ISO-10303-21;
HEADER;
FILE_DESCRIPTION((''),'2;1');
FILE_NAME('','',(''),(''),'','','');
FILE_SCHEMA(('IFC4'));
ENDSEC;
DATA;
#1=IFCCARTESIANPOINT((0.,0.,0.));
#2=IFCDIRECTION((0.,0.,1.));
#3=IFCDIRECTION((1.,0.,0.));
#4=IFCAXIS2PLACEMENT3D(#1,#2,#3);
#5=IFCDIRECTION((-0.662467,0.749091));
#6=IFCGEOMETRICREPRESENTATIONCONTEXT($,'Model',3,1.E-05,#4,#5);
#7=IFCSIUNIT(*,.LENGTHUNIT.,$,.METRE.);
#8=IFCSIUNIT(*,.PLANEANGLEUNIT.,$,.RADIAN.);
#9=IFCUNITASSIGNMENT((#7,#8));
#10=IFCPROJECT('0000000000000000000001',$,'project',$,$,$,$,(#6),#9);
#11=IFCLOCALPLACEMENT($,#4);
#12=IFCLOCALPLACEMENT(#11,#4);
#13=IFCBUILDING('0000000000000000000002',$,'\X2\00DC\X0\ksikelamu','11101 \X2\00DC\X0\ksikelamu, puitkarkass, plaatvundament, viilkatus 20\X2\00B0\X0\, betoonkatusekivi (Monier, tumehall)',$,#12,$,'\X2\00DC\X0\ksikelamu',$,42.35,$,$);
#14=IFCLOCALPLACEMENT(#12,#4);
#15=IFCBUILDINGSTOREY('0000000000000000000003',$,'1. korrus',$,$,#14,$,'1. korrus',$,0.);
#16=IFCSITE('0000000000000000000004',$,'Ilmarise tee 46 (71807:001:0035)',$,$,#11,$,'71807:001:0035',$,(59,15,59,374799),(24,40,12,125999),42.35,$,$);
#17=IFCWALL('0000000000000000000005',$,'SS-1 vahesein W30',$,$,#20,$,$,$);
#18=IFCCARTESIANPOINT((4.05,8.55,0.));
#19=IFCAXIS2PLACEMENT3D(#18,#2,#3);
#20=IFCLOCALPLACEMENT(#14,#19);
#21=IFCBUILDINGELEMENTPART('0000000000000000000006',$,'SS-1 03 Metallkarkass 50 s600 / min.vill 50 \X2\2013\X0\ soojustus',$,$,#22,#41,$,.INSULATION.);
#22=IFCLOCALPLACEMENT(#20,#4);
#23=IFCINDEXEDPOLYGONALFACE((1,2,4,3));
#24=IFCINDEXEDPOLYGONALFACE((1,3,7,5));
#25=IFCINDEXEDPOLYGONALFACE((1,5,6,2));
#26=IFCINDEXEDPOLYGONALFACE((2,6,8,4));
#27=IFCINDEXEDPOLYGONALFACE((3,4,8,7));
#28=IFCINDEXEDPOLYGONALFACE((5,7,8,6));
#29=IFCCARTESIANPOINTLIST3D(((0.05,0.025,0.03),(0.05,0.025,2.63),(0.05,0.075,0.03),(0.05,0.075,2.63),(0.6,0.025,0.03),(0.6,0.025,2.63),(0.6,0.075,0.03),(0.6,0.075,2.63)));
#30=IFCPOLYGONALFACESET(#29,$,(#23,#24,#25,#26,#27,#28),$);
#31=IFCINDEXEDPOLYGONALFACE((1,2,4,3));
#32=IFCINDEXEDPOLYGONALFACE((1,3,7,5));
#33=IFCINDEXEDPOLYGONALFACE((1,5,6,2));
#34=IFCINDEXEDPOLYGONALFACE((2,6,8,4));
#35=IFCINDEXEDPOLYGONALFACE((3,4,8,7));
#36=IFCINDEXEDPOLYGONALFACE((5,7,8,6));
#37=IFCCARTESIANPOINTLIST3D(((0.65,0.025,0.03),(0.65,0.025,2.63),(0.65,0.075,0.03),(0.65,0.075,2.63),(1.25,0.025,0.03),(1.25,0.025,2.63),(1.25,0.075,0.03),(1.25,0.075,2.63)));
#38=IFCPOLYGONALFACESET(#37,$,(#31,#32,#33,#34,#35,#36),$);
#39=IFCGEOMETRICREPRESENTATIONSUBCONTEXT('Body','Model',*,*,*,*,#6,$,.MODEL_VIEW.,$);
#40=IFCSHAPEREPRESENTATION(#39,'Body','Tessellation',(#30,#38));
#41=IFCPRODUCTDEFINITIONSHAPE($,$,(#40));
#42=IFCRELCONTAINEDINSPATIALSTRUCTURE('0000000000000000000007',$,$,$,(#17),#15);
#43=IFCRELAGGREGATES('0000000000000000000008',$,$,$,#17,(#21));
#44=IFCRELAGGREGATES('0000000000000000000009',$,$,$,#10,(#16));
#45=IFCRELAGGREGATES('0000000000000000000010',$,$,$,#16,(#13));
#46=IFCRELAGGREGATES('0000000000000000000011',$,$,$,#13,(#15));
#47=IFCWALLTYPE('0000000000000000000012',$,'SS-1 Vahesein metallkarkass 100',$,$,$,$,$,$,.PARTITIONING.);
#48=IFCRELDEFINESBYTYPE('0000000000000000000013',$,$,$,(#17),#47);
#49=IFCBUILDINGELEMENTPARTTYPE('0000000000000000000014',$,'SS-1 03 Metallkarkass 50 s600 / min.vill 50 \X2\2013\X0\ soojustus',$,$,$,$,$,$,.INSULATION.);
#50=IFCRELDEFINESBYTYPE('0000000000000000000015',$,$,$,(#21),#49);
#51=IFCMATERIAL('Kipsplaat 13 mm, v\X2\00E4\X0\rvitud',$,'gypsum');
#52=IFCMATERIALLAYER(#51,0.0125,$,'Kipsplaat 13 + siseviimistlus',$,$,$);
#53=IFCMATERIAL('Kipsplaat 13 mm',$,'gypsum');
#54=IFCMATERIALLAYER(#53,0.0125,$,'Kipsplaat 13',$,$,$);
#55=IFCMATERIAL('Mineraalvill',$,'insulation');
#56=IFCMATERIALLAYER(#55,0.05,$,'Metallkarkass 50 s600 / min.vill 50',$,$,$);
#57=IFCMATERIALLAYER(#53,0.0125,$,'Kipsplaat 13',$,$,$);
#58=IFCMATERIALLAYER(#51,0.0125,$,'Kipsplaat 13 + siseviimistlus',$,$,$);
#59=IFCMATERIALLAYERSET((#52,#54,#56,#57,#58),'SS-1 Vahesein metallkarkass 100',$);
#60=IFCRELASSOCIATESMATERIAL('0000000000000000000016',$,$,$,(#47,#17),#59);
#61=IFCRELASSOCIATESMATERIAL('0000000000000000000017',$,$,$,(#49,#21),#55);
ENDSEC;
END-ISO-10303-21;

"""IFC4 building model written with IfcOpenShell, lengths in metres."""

from ifc_helpers import new_model, si_unit, direction, frame, origin_with_axes, place, context, subcontext, project, spatial, indexed_curve, outline, extrude, material, layer, layer_set, layer_usage, type_object, element, aggregate, save


model = new_model("IFC4")

# Units and contexts
model_context = context("Model", 3, precision=1e-05, world=origin_with_axes(), true_north=direction((-0.662467, 0.749091)))
body_context = subcontext(model_context, "Body", "Model", "MODEL_VIEW")
ifc_project = project(units=[si_unit("LENGTHUNIT", "METRE"), si_unit("PLANEANGLEUNIT", "RADIAN")], contexts=[model_context])

# Site, building, storey
site_placement = place(None, origin_with_axes())
site = spatial("IfcSite", under=ifc_project, at=site_placement, Name="Ilmarise tee 46 (71807:001:0035)", LongName="71807:001:0035", RefLatitude=(59, 15, 59, 374799), RefLongitude=(24, 40, 12, 125999), RefElevation=42.35)
building_placement = place(site_placement, origin_with_axes())
building = spatial("IfcBuilding", under=site, at=building_placement, Name="Üksikelamu", Description="11101 Üksikelamu, puitkarkass, plaatvundament, viilkatus 20°, betoonkatusekivi (Monier, tumehall)", LongName="Üksikelamu", ElevationOfRefHeight=42.35)
storey_placement = place(building_placement, origin_with_axes())
storey = spatial("IfcBuildingStorey", under=building, at=storey_placement, Name="1. korrus", LongName="1. korrus", Elevation=0.0)

# Wall
ifc_material_1 = material(Name="Kipsplaat 13 mm, värvitud", Category="gypsum")
ifc_layer_1 = layer(ifc_material_1, 0.0125, Name="Kipsplaat 13 + siseviimistlus")
ifc_material_2 = material(Name="Kipsplaat 13 mm", Category="gypsum")
ifc_layer_2 = layer(ifc_material_2, 0.0125, Name="Kipsplaat 13")
ifc_material_3 = material(Name="Mineraalvill", Category="insulation")
ifc_layer_3 = layer(ifc_material_3, 0.05, Name="Metallkarkass 50 s600 / min.vill 50")
ifc_layer_4 = layer(ifc_material_2, 0.0125, Name="Kipsplaat 13")
ifc_layer_5 = layer(ifc_material_1, 0.0125, Name="Kipsplaat 13 + siseviimistlus")
ifc_layer_set = layer_set([ifc_layer_1, ifc_layer_2, ifc_layer_3, ifc_layer_4, ifc_layer_5], Name="SS-1 Vahesein metallkarkass 100")
ifc_layer_usage = layer_usage(ifc_layer_set, "AXIS2", "POSITIVE", 0.0)
wall_type = type_object("IfcWallType", Name="SS-1 Vahesein metallkarkass 100", PredefinedType="PARTITIONING", material=ifc_layer_set)
wall_placement = place(storey_placement, frame((4.05, 8.55, 0.0), z_axis=(0.0, 0.0, 1.0), x_axis=(1.0, 0.0, 0.0)))
wall = element("IfcWall", 1, at=wall_placement, inside=storey, type_object=wall_type, material=ifc_layer_usage, Name="SS-1 vahesein W30")

# Building element part
building_element_part_type_1 = type_object("IfcBuildingElementPartType", Name="SS-1 03 Metallkarkass 50 s600 / min.vill 50 – soojustus", PredefinedType="INSULATION", material=ifc_material_3)
building_element_part_1_placement = place(wall_placement, origin_with_axes())
building_element_part_1 = element("IfcBuildingElementPart", 2, at=building_element_part_1_placement, type_object=building_element_part_type_1, material=ifc_material_3, Name="SS-1 03 Metallkarkass 50 s600 / min.vill 50 – soojustus", PredefinedType="INSULATION", context=body_context, shape_type="SweptSolid", body=[
    extrude(outline(indexed_curve([(0.05, 0.03), (0.05, 2.63), (0.6, 2.63), (0.6, 0.03), (0.05, 0.03)], self_intersect=False)), frame((0.0, 0.075, 0.0), z_axis=(0.0, -1.0, 0.0), x_axis=(1.0, 0.0, 0.0)), (0.0, 0.0, 1.0), 0.05),
    extrude(outline(indexed_curve([(1.25, 0.03), (0.65, 0.03), (0.65, 2.63), (1.25, 2.63), (1.25, 0.03)], self_intersect=False)), frame((0.0, 0.075, 0.0), z_axis=(0.0, -1.0, 0.0), x_axis=(1.0, 0.0, 0.0)), (0.0, 0.0, 1.0), 0.05),
])
aggregate(wall, [building_element_part_1])

save(model, "model.ifc")
